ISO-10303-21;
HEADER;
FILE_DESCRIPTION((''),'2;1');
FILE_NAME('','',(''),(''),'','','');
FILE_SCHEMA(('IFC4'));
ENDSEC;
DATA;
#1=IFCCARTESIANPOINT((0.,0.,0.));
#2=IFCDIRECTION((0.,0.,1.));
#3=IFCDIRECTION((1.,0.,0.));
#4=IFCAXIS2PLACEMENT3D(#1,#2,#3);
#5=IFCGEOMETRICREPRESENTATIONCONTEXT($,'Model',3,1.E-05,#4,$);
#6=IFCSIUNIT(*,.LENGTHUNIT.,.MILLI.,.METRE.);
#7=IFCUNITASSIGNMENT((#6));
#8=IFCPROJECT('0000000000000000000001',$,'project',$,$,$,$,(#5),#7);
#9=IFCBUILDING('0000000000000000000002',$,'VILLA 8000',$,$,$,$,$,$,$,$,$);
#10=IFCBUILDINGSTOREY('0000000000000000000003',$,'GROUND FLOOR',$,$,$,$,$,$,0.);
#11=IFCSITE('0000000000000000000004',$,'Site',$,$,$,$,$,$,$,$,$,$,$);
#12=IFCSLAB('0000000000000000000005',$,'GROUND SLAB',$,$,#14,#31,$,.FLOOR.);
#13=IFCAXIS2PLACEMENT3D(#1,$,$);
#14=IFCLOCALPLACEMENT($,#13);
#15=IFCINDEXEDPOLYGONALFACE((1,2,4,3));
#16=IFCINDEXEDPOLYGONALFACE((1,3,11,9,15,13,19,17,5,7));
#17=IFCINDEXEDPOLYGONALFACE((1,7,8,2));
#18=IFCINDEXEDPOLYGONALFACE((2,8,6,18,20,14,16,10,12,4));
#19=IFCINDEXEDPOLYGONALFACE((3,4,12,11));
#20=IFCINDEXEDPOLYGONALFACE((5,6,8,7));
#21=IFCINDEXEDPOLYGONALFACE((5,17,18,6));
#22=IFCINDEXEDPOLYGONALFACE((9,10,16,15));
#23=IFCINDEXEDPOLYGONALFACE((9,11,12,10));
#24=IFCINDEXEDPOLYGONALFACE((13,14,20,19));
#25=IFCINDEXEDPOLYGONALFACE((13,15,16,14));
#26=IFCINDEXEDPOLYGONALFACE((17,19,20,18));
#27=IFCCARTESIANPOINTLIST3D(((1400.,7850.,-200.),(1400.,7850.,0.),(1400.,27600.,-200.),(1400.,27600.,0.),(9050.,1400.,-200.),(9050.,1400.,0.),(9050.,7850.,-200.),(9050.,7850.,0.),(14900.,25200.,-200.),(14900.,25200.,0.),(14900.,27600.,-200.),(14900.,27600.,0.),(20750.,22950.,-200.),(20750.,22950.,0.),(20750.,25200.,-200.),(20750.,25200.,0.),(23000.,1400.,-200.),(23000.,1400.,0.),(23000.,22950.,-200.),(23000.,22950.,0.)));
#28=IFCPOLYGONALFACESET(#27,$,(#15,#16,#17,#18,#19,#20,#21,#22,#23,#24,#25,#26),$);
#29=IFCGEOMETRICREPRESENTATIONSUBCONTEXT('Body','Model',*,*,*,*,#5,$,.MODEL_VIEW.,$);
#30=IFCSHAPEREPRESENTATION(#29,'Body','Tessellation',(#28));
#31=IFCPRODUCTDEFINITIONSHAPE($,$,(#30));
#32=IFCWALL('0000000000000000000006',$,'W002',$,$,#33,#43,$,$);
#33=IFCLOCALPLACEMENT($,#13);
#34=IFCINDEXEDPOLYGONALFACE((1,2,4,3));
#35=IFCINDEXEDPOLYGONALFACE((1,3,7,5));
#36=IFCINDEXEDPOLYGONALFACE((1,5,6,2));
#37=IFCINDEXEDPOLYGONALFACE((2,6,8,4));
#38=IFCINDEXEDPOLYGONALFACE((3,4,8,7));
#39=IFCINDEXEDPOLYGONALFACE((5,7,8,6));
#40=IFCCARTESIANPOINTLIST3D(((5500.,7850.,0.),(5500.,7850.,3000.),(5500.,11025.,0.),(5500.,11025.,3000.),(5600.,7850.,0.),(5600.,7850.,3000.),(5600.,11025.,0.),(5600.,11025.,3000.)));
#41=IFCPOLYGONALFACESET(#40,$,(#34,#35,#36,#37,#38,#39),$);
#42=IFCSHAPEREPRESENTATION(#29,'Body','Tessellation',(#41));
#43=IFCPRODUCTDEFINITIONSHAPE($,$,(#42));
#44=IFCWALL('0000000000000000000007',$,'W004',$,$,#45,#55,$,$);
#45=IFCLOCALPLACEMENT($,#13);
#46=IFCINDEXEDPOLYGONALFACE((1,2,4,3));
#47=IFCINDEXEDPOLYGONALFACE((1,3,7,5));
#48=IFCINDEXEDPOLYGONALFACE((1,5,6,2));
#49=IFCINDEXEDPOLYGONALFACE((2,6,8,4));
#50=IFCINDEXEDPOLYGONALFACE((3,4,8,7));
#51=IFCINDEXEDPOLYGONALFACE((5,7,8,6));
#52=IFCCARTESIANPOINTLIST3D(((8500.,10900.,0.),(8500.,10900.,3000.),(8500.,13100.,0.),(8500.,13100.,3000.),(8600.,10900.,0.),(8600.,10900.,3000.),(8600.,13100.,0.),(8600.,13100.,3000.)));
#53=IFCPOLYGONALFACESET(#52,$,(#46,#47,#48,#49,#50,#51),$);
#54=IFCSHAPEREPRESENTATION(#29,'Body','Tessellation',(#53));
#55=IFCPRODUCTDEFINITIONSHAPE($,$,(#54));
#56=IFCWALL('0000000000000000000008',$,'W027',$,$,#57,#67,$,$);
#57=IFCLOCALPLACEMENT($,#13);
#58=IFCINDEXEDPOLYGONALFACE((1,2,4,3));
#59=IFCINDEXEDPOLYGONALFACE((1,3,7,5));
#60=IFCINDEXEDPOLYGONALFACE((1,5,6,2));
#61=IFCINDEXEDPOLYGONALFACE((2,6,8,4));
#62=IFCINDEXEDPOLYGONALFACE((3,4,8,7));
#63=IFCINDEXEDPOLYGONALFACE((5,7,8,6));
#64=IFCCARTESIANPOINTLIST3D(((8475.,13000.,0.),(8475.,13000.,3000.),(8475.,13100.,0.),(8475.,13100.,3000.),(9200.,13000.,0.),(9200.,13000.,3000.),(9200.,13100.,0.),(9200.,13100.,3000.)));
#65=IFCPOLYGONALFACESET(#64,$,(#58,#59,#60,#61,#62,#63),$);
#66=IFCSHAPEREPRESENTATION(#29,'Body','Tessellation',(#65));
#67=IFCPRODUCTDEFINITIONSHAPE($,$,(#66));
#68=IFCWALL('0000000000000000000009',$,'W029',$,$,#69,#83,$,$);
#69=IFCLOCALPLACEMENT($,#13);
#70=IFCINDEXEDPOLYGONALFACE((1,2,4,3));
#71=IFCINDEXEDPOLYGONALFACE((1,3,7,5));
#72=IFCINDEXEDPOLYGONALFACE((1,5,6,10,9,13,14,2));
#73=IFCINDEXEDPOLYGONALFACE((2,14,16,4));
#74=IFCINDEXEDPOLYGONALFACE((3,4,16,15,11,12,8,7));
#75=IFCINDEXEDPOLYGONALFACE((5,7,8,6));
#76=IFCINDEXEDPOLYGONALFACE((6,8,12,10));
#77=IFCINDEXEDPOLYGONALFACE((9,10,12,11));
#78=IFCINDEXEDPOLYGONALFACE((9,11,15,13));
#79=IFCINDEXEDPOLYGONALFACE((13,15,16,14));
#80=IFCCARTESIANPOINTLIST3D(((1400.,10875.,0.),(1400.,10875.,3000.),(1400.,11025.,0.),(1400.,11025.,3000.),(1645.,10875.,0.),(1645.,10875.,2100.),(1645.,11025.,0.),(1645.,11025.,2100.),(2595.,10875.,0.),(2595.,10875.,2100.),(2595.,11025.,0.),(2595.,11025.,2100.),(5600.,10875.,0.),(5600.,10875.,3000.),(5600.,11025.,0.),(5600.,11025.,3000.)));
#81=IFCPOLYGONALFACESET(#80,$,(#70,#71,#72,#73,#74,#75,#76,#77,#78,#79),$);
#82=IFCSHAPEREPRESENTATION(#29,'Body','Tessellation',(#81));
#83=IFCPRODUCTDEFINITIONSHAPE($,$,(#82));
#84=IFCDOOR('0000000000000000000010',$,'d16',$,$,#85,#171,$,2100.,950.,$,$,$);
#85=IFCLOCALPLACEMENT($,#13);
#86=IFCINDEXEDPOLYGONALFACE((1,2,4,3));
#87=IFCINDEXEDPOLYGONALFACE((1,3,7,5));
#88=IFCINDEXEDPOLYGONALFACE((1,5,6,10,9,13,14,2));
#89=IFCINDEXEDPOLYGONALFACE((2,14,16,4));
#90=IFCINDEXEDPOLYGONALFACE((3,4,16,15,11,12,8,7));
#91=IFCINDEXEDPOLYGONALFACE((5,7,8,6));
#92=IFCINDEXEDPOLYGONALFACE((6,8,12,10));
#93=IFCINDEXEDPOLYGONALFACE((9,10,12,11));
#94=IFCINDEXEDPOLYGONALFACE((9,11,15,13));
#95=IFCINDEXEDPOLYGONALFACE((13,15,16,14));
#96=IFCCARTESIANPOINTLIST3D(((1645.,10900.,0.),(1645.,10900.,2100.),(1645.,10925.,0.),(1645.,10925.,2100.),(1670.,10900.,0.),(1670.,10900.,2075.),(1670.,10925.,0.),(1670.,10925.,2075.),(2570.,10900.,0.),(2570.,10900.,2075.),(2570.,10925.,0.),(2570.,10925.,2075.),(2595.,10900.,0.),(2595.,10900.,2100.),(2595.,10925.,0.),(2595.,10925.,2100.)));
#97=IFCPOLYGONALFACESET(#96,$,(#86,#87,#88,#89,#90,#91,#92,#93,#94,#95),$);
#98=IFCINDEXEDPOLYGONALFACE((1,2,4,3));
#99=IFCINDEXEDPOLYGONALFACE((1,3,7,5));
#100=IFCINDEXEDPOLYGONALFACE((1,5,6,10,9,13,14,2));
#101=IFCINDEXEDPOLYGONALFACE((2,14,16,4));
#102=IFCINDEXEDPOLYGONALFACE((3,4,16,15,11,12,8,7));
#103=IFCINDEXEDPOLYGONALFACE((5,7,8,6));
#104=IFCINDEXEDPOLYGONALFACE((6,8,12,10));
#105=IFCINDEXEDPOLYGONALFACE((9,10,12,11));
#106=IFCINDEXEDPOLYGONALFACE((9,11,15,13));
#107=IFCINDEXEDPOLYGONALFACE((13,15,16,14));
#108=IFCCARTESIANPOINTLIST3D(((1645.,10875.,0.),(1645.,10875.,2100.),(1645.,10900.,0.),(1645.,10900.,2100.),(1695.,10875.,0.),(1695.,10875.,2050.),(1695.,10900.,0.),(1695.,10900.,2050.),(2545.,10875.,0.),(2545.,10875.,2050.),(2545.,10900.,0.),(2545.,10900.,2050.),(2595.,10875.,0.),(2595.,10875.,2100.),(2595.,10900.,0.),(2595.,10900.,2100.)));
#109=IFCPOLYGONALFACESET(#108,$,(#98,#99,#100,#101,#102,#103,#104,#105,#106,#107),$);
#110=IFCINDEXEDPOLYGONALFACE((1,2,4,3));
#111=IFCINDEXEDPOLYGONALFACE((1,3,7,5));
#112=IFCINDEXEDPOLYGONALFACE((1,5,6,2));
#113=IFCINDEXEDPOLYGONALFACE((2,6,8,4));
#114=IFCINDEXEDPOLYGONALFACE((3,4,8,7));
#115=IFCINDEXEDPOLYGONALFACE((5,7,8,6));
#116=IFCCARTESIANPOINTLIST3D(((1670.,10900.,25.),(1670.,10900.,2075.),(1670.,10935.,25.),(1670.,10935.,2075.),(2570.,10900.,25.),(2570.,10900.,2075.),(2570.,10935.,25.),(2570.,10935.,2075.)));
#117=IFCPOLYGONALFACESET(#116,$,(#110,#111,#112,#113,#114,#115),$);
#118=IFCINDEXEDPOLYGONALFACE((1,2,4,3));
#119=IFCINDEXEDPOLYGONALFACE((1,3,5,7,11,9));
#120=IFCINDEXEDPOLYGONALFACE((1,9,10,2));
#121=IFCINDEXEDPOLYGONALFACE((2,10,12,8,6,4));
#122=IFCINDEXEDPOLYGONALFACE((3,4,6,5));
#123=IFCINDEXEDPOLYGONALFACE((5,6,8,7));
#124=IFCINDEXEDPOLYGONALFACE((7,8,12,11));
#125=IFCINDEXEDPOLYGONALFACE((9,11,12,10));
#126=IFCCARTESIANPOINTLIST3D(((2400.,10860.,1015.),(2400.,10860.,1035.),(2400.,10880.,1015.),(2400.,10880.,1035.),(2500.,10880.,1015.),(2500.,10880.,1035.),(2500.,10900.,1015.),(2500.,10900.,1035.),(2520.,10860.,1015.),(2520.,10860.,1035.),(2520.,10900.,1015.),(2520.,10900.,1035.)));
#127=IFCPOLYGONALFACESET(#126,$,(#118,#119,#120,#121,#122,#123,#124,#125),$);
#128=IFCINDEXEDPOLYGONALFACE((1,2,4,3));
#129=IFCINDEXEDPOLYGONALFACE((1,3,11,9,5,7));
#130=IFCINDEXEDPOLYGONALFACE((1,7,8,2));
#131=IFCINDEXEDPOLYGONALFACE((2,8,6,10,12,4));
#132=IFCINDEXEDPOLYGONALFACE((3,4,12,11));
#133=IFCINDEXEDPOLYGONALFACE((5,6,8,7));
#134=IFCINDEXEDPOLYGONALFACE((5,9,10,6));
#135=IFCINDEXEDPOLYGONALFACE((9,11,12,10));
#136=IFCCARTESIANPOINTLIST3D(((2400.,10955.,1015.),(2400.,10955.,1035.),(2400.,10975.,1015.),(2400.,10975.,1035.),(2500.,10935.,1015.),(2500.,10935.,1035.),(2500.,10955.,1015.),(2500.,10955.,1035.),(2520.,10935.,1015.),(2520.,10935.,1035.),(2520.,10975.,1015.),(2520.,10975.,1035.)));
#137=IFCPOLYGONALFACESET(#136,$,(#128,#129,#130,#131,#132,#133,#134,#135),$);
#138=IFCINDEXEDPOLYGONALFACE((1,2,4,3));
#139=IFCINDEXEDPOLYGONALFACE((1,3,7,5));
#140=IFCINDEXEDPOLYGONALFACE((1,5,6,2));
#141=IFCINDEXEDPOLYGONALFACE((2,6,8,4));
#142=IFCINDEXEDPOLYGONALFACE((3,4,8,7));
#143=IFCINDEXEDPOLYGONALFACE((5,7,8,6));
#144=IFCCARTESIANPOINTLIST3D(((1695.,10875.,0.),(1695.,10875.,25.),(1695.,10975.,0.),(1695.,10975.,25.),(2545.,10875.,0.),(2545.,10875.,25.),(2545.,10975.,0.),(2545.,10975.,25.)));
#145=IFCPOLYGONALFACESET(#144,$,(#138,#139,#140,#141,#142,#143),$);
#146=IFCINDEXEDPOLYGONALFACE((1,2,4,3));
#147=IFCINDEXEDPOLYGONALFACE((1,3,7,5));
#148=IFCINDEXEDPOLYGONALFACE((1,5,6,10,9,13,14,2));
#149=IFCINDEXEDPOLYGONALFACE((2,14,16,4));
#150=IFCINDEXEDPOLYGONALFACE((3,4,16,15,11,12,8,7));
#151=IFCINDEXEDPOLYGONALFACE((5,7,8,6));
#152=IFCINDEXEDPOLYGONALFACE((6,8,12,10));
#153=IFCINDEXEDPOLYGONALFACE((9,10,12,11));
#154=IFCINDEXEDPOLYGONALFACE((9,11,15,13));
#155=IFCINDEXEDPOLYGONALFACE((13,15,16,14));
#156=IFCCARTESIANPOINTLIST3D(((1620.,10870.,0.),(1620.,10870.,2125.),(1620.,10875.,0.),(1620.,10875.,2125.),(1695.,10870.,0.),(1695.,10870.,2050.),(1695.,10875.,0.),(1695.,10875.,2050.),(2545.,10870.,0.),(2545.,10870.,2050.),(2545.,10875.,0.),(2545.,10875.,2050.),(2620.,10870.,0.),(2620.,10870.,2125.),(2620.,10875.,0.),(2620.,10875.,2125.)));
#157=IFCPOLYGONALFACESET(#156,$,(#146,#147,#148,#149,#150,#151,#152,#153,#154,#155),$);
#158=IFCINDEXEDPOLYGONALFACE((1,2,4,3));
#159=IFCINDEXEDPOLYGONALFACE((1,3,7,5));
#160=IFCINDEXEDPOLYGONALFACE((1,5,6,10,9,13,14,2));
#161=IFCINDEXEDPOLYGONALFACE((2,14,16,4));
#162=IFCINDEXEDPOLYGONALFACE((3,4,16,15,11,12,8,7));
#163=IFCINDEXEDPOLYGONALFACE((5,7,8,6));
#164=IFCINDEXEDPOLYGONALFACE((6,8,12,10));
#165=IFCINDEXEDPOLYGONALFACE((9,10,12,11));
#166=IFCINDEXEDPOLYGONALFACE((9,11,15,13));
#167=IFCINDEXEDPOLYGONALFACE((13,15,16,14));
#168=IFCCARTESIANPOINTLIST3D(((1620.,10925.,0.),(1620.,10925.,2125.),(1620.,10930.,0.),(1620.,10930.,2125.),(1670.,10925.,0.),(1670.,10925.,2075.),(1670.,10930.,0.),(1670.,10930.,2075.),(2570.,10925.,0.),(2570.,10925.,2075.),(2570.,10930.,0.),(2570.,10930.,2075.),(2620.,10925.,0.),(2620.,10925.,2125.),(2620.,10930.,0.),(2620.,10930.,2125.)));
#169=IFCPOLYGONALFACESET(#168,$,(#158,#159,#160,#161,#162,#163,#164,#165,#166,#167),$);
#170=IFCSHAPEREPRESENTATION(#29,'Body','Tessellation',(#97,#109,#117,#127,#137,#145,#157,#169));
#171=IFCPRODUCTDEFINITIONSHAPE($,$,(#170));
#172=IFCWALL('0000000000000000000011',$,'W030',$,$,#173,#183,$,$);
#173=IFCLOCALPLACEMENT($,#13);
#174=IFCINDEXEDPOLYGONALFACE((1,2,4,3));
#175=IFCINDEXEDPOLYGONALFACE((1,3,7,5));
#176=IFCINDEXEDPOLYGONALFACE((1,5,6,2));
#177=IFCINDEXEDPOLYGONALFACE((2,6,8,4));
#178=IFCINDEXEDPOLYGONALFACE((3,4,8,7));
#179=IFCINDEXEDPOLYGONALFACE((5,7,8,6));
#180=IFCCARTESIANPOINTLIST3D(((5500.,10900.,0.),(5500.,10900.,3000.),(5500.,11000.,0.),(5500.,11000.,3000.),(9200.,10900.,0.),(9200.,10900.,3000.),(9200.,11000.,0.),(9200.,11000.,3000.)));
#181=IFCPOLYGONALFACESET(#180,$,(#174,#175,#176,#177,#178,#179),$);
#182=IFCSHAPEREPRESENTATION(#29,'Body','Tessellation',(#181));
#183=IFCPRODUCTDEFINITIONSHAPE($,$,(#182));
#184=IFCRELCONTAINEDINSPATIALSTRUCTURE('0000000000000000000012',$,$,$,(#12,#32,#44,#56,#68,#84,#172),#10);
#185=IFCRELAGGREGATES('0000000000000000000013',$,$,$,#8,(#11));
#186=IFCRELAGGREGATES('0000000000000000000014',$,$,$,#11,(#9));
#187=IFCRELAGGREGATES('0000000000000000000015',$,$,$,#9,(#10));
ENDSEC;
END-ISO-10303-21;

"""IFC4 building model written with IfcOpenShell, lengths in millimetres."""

from ifc_helpers import new_model, si_unit, frame, origin_with_axes, place, context, subcontext, project, spatial, line, indexed_curve, outline, extrude, element, fill, save


model = new_model("IFC4")

# Units and contexts
model_context = context("Model", 3, precision=1e-05, world=origin_with_axes())
body_context = subcontext(model_context, "Body", "Model", "MODEL_VIEW")
ifc_project = project(units=[si_unit("LENGTHUNIT", "METRE", prefix="MILLI")], contexts=[model_context])

# Site, building, storey
site = spatial("IfcSite", under=ifc_project, Name="Site")
building = spatial("IfcBuilding", under=site, Name="VILLA 8000")
storey = spatial("IfcBuildingStorey", under=building, Name="GROUND FLOOR", Elevation=0.0)

# Slab
slab_placement = place(None, frame((0.0, 0.0, -200.0), z_axis=(0.0, 0.0, 1.0), x_axis=(1.0, 0.0, 0.0)))
element("IfcSlab", 1, at=slab_placement, inside=storey, Name="GROUND SLAB", PredefinedType="FLOOR", context=body_context, shape_type="SweptSolid", body=[
    extrude(outline(indexed_curve([(1400.0, 7850.0), (9050.0, 7850.0), (9050.0, 1400.0), (23000.0, 1400.0), (23000.0, 22950.0), (20750.0, 22950.0), (20750.0, 25200.0), (14900.0, 25200.0), (14900.0, 27600.0), (1400.0, 27600.0)])), None, (0.0, 0.0, 1.0), 200.0),
])

# Walls
wall_1_placement = place(None, frame((5550.0, 11025.0, 0.0), z_axis=(0.0, 0.0, 1.0), x_axis=(0.0, -1.0, 0.0)))
element("IfcWall", 2, at=wall_1_placement, inside=storey, Name="W002", context=body_context, shape_type="SweptSolid", body=[
    extrude(outline(indexed_curve([(0.0, 0.0), (0.0, 100.0), (3175.0, 100.0), (3175.0, 0.0), (0.0, 0.0)], self_intersect=False)), frame((0.0, -50.0, 0.0), z_axis=(0.0, 0.0, 1.0), x_axis=(1.0, 0.0, 0.0)), (0.0, 0.0, 1.0), 3000.0),
])
wall_2_placement = place(None, frame((8550.0, 13100.0, 0.0), z_axis=(0.0, 0.0, 1.0), x_axis=(0.0, -1.0, 0.0)))
element("IfcWall", 3, at=wall_2_placement, inside=storey, Name="W004", context=body_context, shape_type="SweptSolid", body=[
    extrude(outline(indexed_curve([(0.0, 0.0), (0.0, 100.0), (2200.0, 100.0), (2200.0, 0.0), (0.0, 0.0)], self_intersect=False)), frame((0.0, -50.0, 0.0), z_axis=(0.0, 0.0, 1.0), x_axis=(1.0, 0.0, 0.0)), (0.0, 0.0, 1.0), 3000.0),
])
wall_3_placement = place(None, frame((8475.0, 13050.0, 0.0), z_axis=(0.0, 0.0, 1.0), x_axis=(1.0, 0.0, 0.0)))
element("IfcWall", 4, at=wall_3_placement, inside=storey, Name="W027", context=body_context, shape_type="SweptSolid", body=[
    extrude(outline(indexed_curve([(0.0, 0.0), (0.0, 100.0), (725.0, 100.0), (725.0, 0.0), (0.0, 0.0)], self_intersect=False)), frame((0.0, -50.0, 0.0), z_axis=(0.0, 0.0, 1.0), x_axis=(1.0, 0.0, 0.0)), (0.0, 0.0, 1.0), 3000.0),
])

# Wall, opening, door
wall_4_placement = place(None, frame((1400.0, 10950.0, 0.0), z_axis=(0.0, 0.0, 1.0), x_axis=(1.0, 0.0, 0.0)))
wall_4 = element("IfcWall", 5, at=wall_4_placement, inside=storey, Name="W029", context=body_context, shape_type="SweptSolid", body=[
    extrude(outline(indexed_curve([(0.0, 0.0), (0.0, 150.0), (4200.0, 150.0), (4200.0, 0.0), (0.0, 0.0)], self_intersect=False)), frame((0.0, -75.0, 0.0), z_axis=(0.0, 0.0, 1.0), x_axis=(1.0, 0.0, 0.0)), (0.0, 0.0, 1.0), 3000.0),
])
opening_1_placement = place(wall_4_placement, frame((245.0, 0.0, 0.0), z_axis=(0.0, 0.0, 1.0), x_axis=(1.0, 0.0, 0.0)))
opening_1 = element("IfcOpeningElement", 6, at=opening_1_placement, cuts=wall_4, context=body_context, shape_type="SweptSolid", body=[
    extrude(outline(indexed_curve([(0.0, 0.0), (0.0, 250.0), (950.0, 250.0), (950.0, 0.0), (0.0, 0.0)], self_intersect=False)), frame((0.0, -125.0, 0.0), z_axis=(0.0, 0.0, 1.0), x_axis=(1.0, 0.0, 0.0)), (0.0, 0.0, 1.0), 2100.0),
])
door_placement = place(None, frame((1645.0, 10875.0, 0.0), z_axis=(0.0, 0.0, 1.0), x_axis=(1.0, 0.0, 0.0)))
door = element("IfcDoor", 7, at=door_placement, inside=storey, Name="d16", OverallHeight=2100.0, OverallWidth=950.0, context=body_context, shape_type="SweptSolid", body=[
    extrude(outline(indexed_curve([(0.0, 0.0), (0.0, 2100.0), (950.0, 2100.0), (950.0, 0.0), (925.0, 0.0), (925.0, 2075.0), (25.0, 2075.0), (25.0, 0.0)], segments=[line(1, 2, 3, 4, 5, 6, 7, 8, 1)])), frame((0.0, 25.0, 0.0), z_axis=(0.0, -1.0, 0.0), x_axis=(1.0, 0.0, 0.0)), (0.0, 0.0, -1.0), 25.0),
    extrude(outline(indexed_curve([(0.0, 0.0), (0.0, 2100.0), (950.0, 2100.0), (950.0, 0.0), (900.0, 0.0), (900.0, 2050.0), (50.0, 2050.0), (50.0, 0.0)], segments=[line(1, 2, 3, 4, 5, 6, 7, 8, 1)])), frame((0.0, 0.0, 0.0), z_axis=(0.0, -1.0, 0.0), x_axis=(1.0, 0.0, 0.0)), (0.0, 0.0, -1.0), 25.0),
    extrude(outline(indexed_curve([(0.0, 0.0), (900.0, 0.0), (900.0, 35.0), (0.0, 35.0)], segments=[line(1, 2, 3, 4, 1)])), frame((25.0, 25.0, 25.0), z_axis=(0.0, 0.0, 1.0), x_axis=(1.0, 0.0, 0.0)), (0.0, 0.0, 1.0), 2050.0),
    extrude(outline(indexed_curve([(0.0, 0.0), (0.0, -40.0), (-120.0, -40.0), (-120.0, -20.0), (-20.0, -20.0), (-20.0, 0.0)], segments=[line(1, 2, 3, 4, 5, 6, 1)])), frame((875.0, 25.0, 1015.0), z_axis=(0.0, 0.0, 1.0), x_axis=(1.0, 0.0, 0.0)), (0.0, 0.0, 1.0), 20.0),
    extrude(outline(indexed_curve([(0.0, 0.0), (0.0, 40.0), (-120.0, 40.0), (-120.0, 20.0), (-20.0, 20.0), (-20.0, 0.0)], segments=[line(1, 2, 3, 4, 5, 6, 1)])), frame((875.0, 60.0, 1015.0), z_axis=(0.0, 0.0, 1.0), x_axis=(1.0, 0.0, 0.0)), (0.0, 0.0, 1.0), 20.0),
    extrude(outline(indexed_curve([(0.0, 0.0), (850.0, 0.0), (850.0, 100.0), (0.0, 100.0)], segments=[line(1, 2, 3, 4, 1)])), frame((50.0, 0.0, 0.0), z_axis=(0.0, 0.0, 1.0), x_axis=(1.0, 0.0, 0.0)), (0.0, 0.0, 1.0), 25.0),
    extrude(outline(indexed_curve([(0.0, 0.0), (0.0, 2125.0), (1000.0, 2125.0), (1000.0, 0.0), (925.0, 0.0), (925.0, 2050.0), (75.0, 2050.0), (75.0, 0.0)], segments=[line(1, 2, 3, 4, 5, 6, 7, 8, 1)])), frame((-25.0, -5.0, 0.0), z_axis=(0.0, -1.0, 0.0), x_axis=(1.0, 0.0, 0.0)), (0.0, 0.0, -1.0), 5.0),
    extrude(outline(indexed_curve([(0.0, 0.0), (0.0, 2125.0), (1000.0, 2125.0), (1000.0, 0.0), (950.0, 0.0), (950.0, 2075.0), (50.0, 2075.0), (50.0, 0.0)], segments=[line(1, 2, 3, 4, 5, 6, 7, 8, 1)])), frame((-25.0, 50.0, 0.0), z_axis=(0.0, -1.0, 0.0), x_axis=(1.0, 0.0, 0.0)), (0.0, 0.0, -1.0), 5.0),
])
fill(opening_1, door)

# Wall
wall_5_placement = place(None, frame((5500.0, 10950.0, 0.0), z_axis=(0.0, 0.0, 1.0), x_axis=(1.0, 0.0, 0.0)))
element("IfcWall", 8, at=wall_5_placement, inside=storey, Name="W030", context=body_context, shape_type="SweptSolid", body=[
    extrude(outline(indexed_curve([(0.0, 0.0), (0.0, 100.0), (3700.0, 100.0), (3700.0, 0.0), (0.0, 0.0)], self_intersect=False)), frame((0.0, -50.0, 0.0), z_axis=(0.0, 0.0, 1.0), x_axis=(1.0, 0.0, 0.0)), (0.0, 0.0, 1.0), 3000.0),
])

save(model, "model.ifc")
